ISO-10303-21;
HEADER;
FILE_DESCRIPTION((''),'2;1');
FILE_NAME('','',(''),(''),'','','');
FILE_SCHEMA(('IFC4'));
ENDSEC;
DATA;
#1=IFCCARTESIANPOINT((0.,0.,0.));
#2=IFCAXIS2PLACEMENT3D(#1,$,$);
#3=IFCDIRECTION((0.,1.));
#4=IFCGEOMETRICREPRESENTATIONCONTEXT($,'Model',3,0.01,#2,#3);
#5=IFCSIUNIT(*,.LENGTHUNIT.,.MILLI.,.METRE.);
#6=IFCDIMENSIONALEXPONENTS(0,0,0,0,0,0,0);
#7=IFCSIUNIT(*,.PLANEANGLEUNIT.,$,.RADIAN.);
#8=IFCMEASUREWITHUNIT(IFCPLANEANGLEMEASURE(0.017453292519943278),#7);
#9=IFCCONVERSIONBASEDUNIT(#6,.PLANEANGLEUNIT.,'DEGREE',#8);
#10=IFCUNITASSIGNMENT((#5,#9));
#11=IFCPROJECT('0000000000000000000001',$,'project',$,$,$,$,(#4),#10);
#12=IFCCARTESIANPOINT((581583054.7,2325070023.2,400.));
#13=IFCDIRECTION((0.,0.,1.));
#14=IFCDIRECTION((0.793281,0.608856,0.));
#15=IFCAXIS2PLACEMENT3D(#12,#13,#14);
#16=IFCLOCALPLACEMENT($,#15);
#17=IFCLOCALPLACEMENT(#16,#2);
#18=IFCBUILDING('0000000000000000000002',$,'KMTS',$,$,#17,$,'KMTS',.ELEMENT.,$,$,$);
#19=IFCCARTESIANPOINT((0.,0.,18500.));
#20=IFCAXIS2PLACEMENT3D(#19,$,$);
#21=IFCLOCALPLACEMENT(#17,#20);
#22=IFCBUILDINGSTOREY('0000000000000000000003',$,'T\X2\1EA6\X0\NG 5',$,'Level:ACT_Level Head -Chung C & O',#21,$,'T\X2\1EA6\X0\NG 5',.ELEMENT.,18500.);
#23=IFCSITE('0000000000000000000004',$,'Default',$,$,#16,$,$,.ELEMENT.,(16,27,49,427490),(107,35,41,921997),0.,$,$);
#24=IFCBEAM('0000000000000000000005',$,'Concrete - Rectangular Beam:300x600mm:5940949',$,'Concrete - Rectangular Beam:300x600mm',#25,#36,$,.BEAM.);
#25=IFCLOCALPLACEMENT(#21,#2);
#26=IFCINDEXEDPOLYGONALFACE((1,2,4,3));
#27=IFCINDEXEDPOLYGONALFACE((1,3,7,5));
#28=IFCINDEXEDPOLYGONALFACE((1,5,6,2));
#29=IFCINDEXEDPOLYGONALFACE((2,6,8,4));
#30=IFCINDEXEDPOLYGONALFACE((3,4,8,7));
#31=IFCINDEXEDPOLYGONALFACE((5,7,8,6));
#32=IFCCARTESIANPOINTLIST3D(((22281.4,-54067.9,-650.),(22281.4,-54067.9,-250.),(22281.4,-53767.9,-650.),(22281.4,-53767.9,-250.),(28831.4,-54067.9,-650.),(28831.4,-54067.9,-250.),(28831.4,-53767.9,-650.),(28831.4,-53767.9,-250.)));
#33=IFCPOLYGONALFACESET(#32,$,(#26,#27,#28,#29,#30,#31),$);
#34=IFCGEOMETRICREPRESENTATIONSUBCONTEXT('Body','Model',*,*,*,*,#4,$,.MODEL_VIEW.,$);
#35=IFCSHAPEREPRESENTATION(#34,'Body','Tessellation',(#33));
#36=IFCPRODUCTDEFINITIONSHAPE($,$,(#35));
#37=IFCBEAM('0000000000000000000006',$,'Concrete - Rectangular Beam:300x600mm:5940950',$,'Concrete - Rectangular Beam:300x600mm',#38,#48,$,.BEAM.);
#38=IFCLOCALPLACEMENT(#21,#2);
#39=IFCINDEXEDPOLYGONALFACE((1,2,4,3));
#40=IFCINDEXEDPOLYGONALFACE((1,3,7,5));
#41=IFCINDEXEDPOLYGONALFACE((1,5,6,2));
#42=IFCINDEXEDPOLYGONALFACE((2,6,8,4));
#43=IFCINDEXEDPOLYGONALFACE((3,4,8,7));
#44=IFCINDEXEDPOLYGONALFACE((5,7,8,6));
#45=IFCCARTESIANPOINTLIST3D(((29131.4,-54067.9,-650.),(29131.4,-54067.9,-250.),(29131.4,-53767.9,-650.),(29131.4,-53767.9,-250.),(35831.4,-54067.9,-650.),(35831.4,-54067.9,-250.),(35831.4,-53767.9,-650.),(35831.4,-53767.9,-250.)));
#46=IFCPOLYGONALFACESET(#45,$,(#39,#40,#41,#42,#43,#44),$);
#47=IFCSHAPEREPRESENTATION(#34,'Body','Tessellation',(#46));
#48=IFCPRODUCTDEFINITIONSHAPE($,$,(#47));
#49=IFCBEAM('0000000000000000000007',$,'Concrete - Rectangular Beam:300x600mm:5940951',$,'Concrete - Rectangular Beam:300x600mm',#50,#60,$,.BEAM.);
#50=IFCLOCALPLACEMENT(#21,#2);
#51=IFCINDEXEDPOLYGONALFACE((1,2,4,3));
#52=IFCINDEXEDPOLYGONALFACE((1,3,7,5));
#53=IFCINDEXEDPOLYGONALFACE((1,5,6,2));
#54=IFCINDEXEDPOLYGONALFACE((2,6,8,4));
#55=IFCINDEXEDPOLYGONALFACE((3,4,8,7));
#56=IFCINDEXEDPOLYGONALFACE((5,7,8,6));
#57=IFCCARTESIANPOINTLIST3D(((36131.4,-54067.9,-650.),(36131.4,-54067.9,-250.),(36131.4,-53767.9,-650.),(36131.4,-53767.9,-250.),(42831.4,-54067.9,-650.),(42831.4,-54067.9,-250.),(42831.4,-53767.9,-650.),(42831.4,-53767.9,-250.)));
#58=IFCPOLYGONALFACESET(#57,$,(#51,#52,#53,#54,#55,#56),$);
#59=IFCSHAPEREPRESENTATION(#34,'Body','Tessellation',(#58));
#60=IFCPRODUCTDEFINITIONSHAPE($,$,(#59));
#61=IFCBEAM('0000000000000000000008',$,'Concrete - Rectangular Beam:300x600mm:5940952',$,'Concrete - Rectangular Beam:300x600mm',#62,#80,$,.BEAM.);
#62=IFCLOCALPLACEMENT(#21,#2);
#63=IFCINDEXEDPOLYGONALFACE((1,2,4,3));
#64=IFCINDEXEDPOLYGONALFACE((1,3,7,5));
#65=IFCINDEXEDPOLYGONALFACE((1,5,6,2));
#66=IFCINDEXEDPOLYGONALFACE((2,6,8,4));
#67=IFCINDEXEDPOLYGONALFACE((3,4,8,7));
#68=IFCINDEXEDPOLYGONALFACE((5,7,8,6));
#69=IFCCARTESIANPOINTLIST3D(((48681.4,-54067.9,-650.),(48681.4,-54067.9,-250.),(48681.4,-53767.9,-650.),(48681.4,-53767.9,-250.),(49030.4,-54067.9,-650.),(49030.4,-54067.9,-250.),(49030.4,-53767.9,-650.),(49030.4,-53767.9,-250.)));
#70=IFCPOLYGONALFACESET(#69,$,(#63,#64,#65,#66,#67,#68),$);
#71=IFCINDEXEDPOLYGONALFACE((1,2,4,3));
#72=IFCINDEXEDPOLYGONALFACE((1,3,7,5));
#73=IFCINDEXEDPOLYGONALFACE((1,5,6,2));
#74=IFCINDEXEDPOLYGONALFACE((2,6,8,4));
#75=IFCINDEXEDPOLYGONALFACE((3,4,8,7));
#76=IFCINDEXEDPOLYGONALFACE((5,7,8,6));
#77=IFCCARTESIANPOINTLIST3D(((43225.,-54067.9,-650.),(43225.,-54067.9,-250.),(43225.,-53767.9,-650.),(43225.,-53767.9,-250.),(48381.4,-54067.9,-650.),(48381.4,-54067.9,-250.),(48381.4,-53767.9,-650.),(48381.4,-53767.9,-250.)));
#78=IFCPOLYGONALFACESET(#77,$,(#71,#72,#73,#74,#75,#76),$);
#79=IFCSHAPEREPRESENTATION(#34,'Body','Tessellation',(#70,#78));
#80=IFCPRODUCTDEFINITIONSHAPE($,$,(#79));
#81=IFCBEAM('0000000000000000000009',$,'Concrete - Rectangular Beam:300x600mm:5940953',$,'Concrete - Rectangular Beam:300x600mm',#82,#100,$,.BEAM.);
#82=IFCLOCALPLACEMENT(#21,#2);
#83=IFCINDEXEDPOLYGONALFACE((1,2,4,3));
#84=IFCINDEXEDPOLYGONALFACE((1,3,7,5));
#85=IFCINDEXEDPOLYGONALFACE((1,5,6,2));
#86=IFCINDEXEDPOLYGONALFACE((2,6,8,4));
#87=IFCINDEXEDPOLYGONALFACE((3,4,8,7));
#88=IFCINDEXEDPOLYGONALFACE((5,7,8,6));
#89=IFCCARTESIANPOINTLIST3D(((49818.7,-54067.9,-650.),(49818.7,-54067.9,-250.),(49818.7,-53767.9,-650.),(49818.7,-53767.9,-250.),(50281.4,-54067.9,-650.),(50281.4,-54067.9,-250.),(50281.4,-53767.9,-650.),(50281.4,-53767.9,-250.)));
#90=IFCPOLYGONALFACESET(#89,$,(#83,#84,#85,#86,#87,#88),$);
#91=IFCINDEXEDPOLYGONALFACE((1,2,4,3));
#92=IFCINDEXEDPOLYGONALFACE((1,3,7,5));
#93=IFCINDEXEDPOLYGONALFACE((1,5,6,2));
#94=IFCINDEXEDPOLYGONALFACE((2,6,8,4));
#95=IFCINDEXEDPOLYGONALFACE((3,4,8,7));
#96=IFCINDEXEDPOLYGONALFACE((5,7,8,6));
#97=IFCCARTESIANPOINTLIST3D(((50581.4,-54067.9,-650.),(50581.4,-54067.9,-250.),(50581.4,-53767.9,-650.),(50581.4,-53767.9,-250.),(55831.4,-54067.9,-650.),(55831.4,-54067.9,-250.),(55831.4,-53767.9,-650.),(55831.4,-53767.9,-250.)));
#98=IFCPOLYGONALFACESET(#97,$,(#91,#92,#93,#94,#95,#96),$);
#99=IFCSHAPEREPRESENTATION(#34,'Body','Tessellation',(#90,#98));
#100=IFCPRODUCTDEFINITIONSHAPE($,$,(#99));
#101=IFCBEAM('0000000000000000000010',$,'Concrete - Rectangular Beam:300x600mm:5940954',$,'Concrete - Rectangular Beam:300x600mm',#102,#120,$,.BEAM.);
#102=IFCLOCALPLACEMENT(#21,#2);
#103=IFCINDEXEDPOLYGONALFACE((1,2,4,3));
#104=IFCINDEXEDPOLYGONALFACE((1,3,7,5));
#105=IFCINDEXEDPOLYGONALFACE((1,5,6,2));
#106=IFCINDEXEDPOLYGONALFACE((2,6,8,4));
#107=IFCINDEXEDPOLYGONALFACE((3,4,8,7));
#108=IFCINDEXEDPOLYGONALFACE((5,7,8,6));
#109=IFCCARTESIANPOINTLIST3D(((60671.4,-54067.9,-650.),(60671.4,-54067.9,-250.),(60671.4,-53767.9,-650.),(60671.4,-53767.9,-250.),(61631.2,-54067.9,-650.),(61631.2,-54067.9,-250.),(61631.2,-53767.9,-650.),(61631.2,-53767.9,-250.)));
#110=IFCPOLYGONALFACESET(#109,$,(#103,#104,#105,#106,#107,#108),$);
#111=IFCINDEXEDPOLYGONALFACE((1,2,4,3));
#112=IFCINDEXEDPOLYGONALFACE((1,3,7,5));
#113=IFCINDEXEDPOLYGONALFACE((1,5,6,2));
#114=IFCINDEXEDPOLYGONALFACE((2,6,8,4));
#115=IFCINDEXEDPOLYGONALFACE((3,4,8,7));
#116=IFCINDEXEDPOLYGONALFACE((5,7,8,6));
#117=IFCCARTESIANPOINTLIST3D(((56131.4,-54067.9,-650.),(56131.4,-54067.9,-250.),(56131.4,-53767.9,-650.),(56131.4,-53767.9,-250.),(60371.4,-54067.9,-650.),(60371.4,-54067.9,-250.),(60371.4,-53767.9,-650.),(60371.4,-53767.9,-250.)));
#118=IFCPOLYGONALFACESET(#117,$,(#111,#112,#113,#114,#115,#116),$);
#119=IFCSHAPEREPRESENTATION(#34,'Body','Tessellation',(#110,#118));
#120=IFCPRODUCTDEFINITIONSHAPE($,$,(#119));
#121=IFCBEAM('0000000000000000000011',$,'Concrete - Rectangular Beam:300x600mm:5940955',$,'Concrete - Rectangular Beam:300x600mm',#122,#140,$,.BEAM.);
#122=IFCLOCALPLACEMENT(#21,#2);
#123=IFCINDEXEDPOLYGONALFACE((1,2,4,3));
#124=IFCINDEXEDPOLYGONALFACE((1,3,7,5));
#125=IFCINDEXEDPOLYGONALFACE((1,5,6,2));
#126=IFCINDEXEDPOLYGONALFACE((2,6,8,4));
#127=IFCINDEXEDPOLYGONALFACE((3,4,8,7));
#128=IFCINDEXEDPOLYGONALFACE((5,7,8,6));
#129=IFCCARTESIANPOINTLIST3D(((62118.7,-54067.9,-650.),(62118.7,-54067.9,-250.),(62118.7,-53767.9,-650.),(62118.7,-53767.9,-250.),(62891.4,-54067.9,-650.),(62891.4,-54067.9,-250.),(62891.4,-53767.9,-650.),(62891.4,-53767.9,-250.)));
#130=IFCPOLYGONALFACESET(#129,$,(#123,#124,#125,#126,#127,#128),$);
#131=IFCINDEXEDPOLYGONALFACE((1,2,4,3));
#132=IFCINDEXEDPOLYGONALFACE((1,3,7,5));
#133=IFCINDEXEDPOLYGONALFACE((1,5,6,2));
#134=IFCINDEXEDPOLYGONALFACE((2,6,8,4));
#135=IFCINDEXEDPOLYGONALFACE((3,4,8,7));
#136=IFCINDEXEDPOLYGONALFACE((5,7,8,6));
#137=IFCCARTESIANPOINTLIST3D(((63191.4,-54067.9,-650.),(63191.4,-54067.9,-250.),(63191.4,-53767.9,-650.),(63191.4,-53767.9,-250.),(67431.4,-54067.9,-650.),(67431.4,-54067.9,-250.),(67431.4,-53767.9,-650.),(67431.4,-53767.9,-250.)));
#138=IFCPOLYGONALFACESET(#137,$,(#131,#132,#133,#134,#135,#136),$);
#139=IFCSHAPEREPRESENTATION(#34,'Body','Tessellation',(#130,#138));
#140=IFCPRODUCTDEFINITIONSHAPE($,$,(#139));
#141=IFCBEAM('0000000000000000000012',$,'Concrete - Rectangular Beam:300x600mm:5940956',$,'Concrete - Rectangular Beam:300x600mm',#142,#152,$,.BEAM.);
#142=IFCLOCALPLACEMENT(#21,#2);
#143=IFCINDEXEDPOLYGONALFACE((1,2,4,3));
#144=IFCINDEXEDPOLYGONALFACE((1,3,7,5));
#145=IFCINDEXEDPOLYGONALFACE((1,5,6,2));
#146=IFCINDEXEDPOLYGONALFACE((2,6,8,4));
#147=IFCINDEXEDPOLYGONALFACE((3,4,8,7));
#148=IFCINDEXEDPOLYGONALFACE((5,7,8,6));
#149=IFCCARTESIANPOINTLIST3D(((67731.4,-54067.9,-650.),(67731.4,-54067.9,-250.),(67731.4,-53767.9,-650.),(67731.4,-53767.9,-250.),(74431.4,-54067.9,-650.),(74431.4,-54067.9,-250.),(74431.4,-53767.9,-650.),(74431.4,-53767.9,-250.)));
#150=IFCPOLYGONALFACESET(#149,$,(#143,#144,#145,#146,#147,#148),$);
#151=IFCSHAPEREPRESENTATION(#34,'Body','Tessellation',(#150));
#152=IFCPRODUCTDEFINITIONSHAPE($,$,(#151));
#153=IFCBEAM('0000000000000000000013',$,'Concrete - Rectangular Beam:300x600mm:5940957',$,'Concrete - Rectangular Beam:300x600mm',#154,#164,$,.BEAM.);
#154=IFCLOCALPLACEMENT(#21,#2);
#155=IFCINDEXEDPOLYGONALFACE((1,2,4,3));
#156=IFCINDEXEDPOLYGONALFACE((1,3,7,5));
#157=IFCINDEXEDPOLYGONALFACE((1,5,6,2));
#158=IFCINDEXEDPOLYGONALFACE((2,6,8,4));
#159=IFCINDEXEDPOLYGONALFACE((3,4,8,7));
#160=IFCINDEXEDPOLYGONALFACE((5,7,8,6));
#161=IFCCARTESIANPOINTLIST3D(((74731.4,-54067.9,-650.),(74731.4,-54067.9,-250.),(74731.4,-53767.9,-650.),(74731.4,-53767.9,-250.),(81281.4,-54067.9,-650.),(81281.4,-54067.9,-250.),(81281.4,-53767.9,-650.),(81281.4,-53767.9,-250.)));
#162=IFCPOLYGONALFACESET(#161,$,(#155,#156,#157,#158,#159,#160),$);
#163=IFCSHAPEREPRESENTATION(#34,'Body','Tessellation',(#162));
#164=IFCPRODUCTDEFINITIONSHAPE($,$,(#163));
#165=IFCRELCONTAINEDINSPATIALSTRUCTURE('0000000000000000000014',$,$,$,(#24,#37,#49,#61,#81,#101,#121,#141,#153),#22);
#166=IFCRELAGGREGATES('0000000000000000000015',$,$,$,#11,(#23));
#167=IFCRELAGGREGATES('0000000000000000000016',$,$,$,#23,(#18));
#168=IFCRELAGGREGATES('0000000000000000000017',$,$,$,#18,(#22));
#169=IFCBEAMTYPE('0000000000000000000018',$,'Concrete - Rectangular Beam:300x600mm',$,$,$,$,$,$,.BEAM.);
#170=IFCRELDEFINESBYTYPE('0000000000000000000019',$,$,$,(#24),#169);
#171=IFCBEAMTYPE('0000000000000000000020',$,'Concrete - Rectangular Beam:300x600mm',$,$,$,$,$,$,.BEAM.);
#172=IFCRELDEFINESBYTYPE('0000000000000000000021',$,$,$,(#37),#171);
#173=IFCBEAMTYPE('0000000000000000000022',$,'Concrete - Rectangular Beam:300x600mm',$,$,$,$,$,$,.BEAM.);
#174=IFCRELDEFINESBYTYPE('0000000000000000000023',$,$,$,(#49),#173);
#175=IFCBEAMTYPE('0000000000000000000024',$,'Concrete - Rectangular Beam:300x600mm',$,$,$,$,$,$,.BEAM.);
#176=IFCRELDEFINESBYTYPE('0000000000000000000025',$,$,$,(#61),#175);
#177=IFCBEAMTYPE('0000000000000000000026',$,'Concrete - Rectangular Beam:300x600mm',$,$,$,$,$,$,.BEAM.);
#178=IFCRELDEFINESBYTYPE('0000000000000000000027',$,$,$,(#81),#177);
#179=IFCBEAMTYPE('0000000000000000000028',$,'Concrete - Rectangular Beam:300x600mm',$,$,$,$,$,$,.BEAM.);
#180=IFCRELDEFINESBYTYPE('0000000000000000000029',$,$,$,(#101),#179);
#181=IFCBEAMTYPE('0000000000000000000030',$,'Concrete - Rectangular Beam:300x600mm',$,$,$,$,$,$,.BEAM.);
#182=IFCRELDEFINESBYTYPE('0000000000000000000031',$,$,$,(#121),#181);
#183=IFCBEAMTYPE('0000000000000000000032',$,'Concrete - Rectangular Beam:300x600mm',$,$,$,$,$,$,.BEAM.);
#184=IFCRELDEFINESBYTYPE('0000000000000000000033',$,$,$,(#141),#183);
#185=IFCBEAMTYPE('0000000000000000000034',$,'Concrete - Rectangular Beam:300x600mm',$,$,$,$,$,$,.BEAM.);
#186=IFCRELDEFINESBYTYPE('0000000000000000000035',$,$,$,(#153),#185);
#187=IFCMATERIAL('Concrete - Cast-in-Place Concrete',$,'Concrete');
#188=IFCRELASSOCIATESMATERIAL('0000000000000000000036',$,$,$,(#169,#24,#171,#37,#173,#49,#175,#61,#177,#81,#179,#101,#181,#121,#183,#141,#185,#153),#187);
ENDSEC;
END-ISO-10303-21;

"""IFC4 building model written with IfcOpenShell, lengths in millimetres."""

from ifc_helpers import new_model, entity, si_unit, converted_unit, direction, frame, origin, place, context, subcontext, project, spatial, indexed_curve, outline, extrude, source, transform, mapped, material, type_object, type_shapes, element, save


model = new_model("IFC4")

# Units and contexts
model_context = context("Model", 3, precision=0.01, world=origin(), true_north=direction((0.0, 1.0)))
body_context = subcontext(model_context, "Body", "Model", "MODEL_VIEW")
ifc_project = project(units=[si_unit("LENGTHUNIT", "METRE", prefix="MILLI"), converted_unit("PLANEANGLEUNIT", "DEGREE", entity("IfcPlaneAngleMeasure", 0.017453292519943278), si_unit("PLANEANGLEUNIT", "RADIAN"), dimensions=[0, 0, 0, 0, 0, 0, 0])], contexts=[model_context])

# Site, building, storey
site_placement = place(None, frame((581583054.7, 2325070023.2, 400.0), z_axis=(0.0, 0.0, 1.0), x_axis=(0.793281, 0.608856, 0.0)))
site = spatial("IfcSite", under=ifc_project, at=site_placement, Name="Default", CompositionType="ELEMENT", RefLatitude=(16, 27, 49, 427490), RefLongitude=(107, 35, 41, 921997), RefElevation=0.0)
building_placement = place(site_placement, origin())
building = spatial("IfcBuilding", under=site, at=building_placement, Name="KMTS", LongName="KMTS", CompositionType="ELEMENT")
storey_placement = place(building_placement, frame((0.0, 0.0, 18500.0)))
storey = spatial("IfcBuildingStorey", under=building, at=storey_placement, Name="TẦNG 5", ObjectType="Level:ACT_Level Head -Chung C & O", LongName="TẦNG 5", CompositionType="ELEMENT", Elevation=18500.0)

# Beams
ifc_material_1 = material(Name="Concrete - Cast-in-Place Concrete", Category="Concrete")
beam_type_1 = type_object("IfcBeamType", Name="Concrete - Rectangular Beam:300x600mm", PredefinedType="BEAM", material=ifc_material_1)
shared_shape_1 = source(origin(), body_context, "Body", "SweptSolid", [
    extrude(outline(indexed_curve([(-200.0, -150.0), (200.0, -150.0), (200.0, 150.0), (-200.0, 150.0), (-200.0, -150.0)], self_intersect=False)), frame((22281.4, -53917.9, 18050.0), z_axis=(1.0, 0.0, 0.0), x_axis=(0.0, 0.0, -1.0)), (0.0, 0.0, 1.0), 6550.0),
])
type_shapes(beam_type_1, [shared_shape_1])
beam_1_placement = place(storey_placement, frame((0.0, 0.0, -18500.0)))
element("IfcBeam", 1, at=beam_1_placement, inside=storey, type_object=beam_type_1, material=ifc_material_1, Name="Concrete - Rectangular Beam:300x600mm:5940949", ObjectType="Concrete - Rectangular Beam:300x600mm", PredefinedType="BEAM", context=body_context, shape_type="MappedRepresentation", body=[
    mapped(shared_shape_1, transform((0.0, 0.0, 0.0), scale=1.0)),
])
beam_type_2 = type_object("IfcBeamType", Name="Concrete - Rectangular Beam:300x600mm", PredefinedType="BEAM", material=ifc_material_1)
shared_shape_2 = source(origin(), body_context, "Body", "SweptSolid", [
    extrude(outline(indexed_curve([(-200.0, -150.0), (200.0, -150.0), (200.0, 150.0), (-200.0, 150.0), (-200.0, -150.0)], self_intersect=False)), frame((29131.4, -53917.9, 18050.0), z_axis=(1.0, 0.0, 0.0), x_axis=(0.0, 0.0, -1.0)), (0.0, 0.0, 1.0), 6700.0),
])
type_shapes(beam_type_2, [shared_shape_2])
beam_2_placement = place(storey_placement, frame((0.0, 0.0, -18500.0)))
element("IfcBeam", 2, at=beam_2_placement, inside=storey, type_object=beam_type_2, material=ifc_material_1, Name="Concrete - Rectangular Beam:300x600mm:5940950", ObjectType="Concrete - Rectangular Beam:300x600mm", PredefinedType="BEAM", context=body_context, shape_type="MappedRepresentation", body=[
    mapped(shared_shape_2, transform((0.0, 0.0, 0.0), scale=1.0)),
])
beam_type_3 = type_object("IfcBeamType", Name="Concrete - Rectangular Beam:300x600mm", PredefinedType="BEAM", material=ifc_material_1)
shared_shape_3 = source(origin(), body_context, "Body", "SweptSolid", [
    extrude(outline(indexed_curve([(-200.0, -150.0), (200.0, -150.0), (200.0, 150.0), (-200.0, 150.0), (-200.0, -150.0)], self_intersect=False)), frame((36131.4, -53917.9, 18050.0), z_axis=(1.0, 0.0, 0.0), x_axis=(0.0, 0.0, -1.0)), (0.0, 0.0, 1.0), 6700.0),
])
type_shapes(beam_type_3, [shared_shape_3])
beam_3_placement = place(storey_placement, frame((0.0, 0.0, -18500.0)))
element("IfcBeam", 3, at=beam_3_placement, inside=storey, type_object=beam_type_3, material=ifc_material_1, Name="Concrete - Rectangular Beam:300x600mm:5940951", ObjectType="Concrete - Rectangular Beam:300x600mm", PredefinedType="BEAM", context=body_context, shape_type="MappedRepresentation", body=[
    mapped(shared_shape_3, transform((0.0, 0.0, 0.0), scale=1.0)),
])
beam_type_4 = type_object("IfcBeamType", Name="Concrete - Rectangular Beam:300x600mm", PredefinedType="BEAM", material=ifc_material_1)
shared_shape_4 = source(origin(), body_context, "Body", "SweptSolid", [
    extrude(outline(indexed_curve([(-200.0, -150.0), (200.0, -150.0), (200.0, 150.0), (-200.0, 150.0), (-200.0, -150.0)], self_intersect=False)), frame((48681.4, -53917.9, 18050.0), z_axis=(1.0, 0.0, 0.0), x_axis=(0.0, 0.0, -1.0)), (0.0, 0.0, 1.0), 349.0),
    extrude(outline(indexed_curve([(-200.0, -150.0), (200.0, -150.0), (200.0, 150.0), (-200.0, 150.0), (-200.0, -150.0)], self_intersect=False)), frame((43225.0, -53917.9, 18050.0), z_axis=(1.0, 0.0, 0.0), x_axis=(0.0, 0.0, -1.0)), (0.0, 0.0, 1.0), 5156.4),
])
type_shapes(beam_type_4, [shared_shape_4])
beam_4_placement = place(storey_placement, frame((0.0, 0.0, -18500.0)))
element("IfcBeam", 4, at=beam_4_placement, inside=storey, type_object=beam_type_4, material=ifc_material_1, Name="Concrete - Rectangular Beam:300x600mm:5940952", ObjectType="Concrete - Rectangular Beam:300x600mm", PredefinedType="BEAM", context=body_context, shape_type="MappedRepresentation", body=[
    mapped(shared_shape_4, transform((0.0, 0.0, 0.0), scale=1.0)),
])
beam_type_5 = type_object("IfcBeamType", Name="Concrete - Rectangular Beam:300x600mm", PredefinedType="BEAM", material=ifc_material_1)
shared_shape_5 = source(origin(), body_context, "Body", "SweptSolid", [
    extrude(outline(indexed_curve([(-200.0, -150.0), (200.0, -150.0), (200.0, 150.0), (-200.0, 150.0), (-200.0, -150.0)], self_intersect=False)), frame((49818.7, -53917.9, 18050.0), z_axis=(1.0, 0.0, 0.0), x_axis=(0.0, 0.0, -1.0)), (0.0, 0.0, 1.0), 462.7),
    extrude(outline(indexed_curve([(-200.0, -150.0), (200.0, -150.0), (200.0, 150.0), (-200.0, 150.0), (-200.0, -150.0)], self_intersect=False)), frame((50581.4, -53917.9, 18050.0), z_axis=(1.0, 0.0, 0.0), x_axis=(0.0, 0.0, -1.0)), (0.0, 0.0, 1.0), 5250.0),
])
type_shapes(beam_type_5, [shared_shape_5])
beam_5_placement = place(storey_placement, frame((0.0, 0.0, -18500.0)))
element("IfcBeam", 5, at=beam_5_placement, inside=storey, type_object=beam_type_5, material=ifc_material_1, Name="Concrete - Rectangular Beam:300x600mm:5940953", ObjectType="Concrete - Rectangular Beam:300x600mm", PredefinedType="BEAM", context=body_context, shape_type="MappedRepresentation", body=[
    mapped(shared_shape_5, transform((0.0, 0.0, 0.0), scale=1.0)),
])
beam_type_6 = type_object("IfcBeamType", Name="Concrete - Rectangular Beam:300x600mm", PredefinedType="BEAM", material=ifc_material_1)
shared_shape_6 = source(origin(), body_context, "Body", "SweptSolid", [
    extrude(outline(indexed_curve([(-200.0, -150.0), (200.0, -150.0), (200.0, 150.0), (-200.0, 150.0), (-200.0, -150.0)], self_intersect=False)), frame((60671.4, -53917.9, 18050.0), z_axis=(1.0, 0.0, 0.0), x_axis=(0.0, 0.0, -1.0)), (0.0, 0.0, 1.0), 959.8),
    extrude(outline(indexed_curve([(-200.0, -150.0), (200.0, -150.0), (200.0, 150.0), (-200.0, 150.0), (-200.0, -150.0)], self_intersect=False)), frame((56131.4, -53917.9, 18050.0), z_axis=(1.0, 0.0, 0.0), x_axis=(0.0, 0.0, -1.0)), (0.0, 0.0, 1.0), 4240.0),
])
type_shapes(beam_type_6, [shared_shape_6])
beam_6_placement = place(storey_placement, frame((0.0, 0.0, -18500.0)))
element("IfcBeam", 6, at=beam_6_placement, inside=storey, type_object=beam_type_6, material=ifc_material_1, Name="Concrete - Rectangular Beam:300x600mm:5940954", ObjectType="Concrete - Rectangular Beam:300x600mm", PredefinedType="BEAM", context=body_context, shape_type="MappedRepresentation", body=[
    mapped(shared_shape_6, transform((0.0, 0.0, 0.0), scale=1.0)),
])
beam_type_7 = type_object("IfcBeamType", Name="Concrete - Rectangular Beam:300x600mm", PredefinedType="BEAM", material=ifc_material_1)
shared_shape_7 = source(origin(), body_context, "Body", "SweptSolid", [
    extrude(outline(indexed_curve([(-200.0, -150.0), (200.0, -150.0), (200.0, 150.0), (-200.0, 150.0), (-200.0, -150.0)], self_intersect=False)), frame((62118.7, -53917.9, 18050.0), z_axis=(1.0, 0.0, 0.0), x_axis=(0.0, 0.0, -1.0)), (0.0, 0.0, 1.0), 772.7),
    extrude(outline(indexed_curve([(-200.0, -150.0), (200.0, -150.0), (200.0, 150.0), (-200.0, 150.0), (-200.0, -150.0)], self_intersect=False)), frame((63191.4, -53917.9, 18050.0), z_axis=(1.0, 0.0, 0.0), x_axis=(0.0, 0.0, -1.0)), (0.0, 0.0, 1.0), 4240.0),
])
type_shapes(beam_type_7, [shared_shape_7])
beam_7_placement = place(storey_placement, frame((0.0, 0.0, -18500.0)))
element("IfcBeam", 7, at=beam_7_placement, inside=storey, type_object=beam_type_7, material=ifc_material_1, Name="Concrete - Rectangular Beam:300x600mm:5940955", ObjectType="Concrete - Rectangular Beam:300x600mm", PredefinedType="BEAM", context=body_context, shape_type="MappedRepresentation", body=[
    mapped(shared_shape_7, transform((0.0, 0.0, 0.0), scale=1.0)),
])
beam_type_8 = type_object("IfcBeamType", Name="Concrete - Rectangular Beam:300x600mm", PredefinedType="BEAM", material=ifc_material_1)
shared_shape_8 = source(origin(), body_context, "Body", "SweptSolid", [
    extrude(outline(indexed_curve([(-200.0, -150.0), (200.0, -150.0), (200.0, 150.0), (-200.0, 150.0), (-200.0, -150.0)], self_intersect=False)), frame((67731.4, -53917.9, 18050.0), z_axis=(1.0, 0.0, 0.0), x_axis=(0.0, 0.0, -1.0)), (0.0, 0.0, 1.0), 6700.0),
])
type_shapes(beam_type_8, [shared_shape_8])
beam_8_placement = place(storey_placement, frame((0.0, 0.0, -18500.0)))
element("IfcBeam", 8, at=beam_8_placement, inside=storey, type_object=beam_type_8, material=ifc_material_1, Name="Concrete - Rectangular Beam:300x600mm:5940956", ObjectType="Concrete - Rectangular Beam:300x600mm", PredefinedType="BEAM", context=body_context, shape_type="MappedRepresentation", body=[
    mapped(shared_shape_8, transform((0.0, 0.0, 0.0), scale=1.0)),
])
beam_type_9 = type_object("IfcBeamType", Name="Concrete - Rectangular Beam:300x600mm", PredefinedType="BEAM", material=ifc_material_1)
shared_shape_9 = source(origin(), body_context, "Body", "SweptSolid", [
    extrude(outline(indexed_curve([(-200.0, -150.0), (200.0, -150.0), (200.0, 150.0), (-200.0, 150.0), (-200.0, -150.0)], self_intersect=False)), frame((74731.4, -53917.9, 18050.0), z_axis=(1.0, 0.0, 0.0), x_axis=(0.0, 0.0, -1.0)), (0.0, 0.0, 1.0), 6550.0),
])
type_shapes(beam_type_9, [shared_shape_9])
beam_9_placement = place(storey_placement, frame((0.0, 0.0, -18500.0)))
element("IfcBeam", 9, at=beam_9_placement, inside=storey, type_object=beam_type_9, material=ifc_material_1, Name="Concrete - Rectangular Beam:300x600mm:5940957", ObjectType="Concrete - Rectangular Beam:300x600mm", PredefinedType="BEAM", context=body_context, shape_type="MappedRepresentation", body=[
    mapped(shared_shape_9, transform((0.0, 0.0, 0.0), scale=1.0)),
])

save(model, "model.ifc")
